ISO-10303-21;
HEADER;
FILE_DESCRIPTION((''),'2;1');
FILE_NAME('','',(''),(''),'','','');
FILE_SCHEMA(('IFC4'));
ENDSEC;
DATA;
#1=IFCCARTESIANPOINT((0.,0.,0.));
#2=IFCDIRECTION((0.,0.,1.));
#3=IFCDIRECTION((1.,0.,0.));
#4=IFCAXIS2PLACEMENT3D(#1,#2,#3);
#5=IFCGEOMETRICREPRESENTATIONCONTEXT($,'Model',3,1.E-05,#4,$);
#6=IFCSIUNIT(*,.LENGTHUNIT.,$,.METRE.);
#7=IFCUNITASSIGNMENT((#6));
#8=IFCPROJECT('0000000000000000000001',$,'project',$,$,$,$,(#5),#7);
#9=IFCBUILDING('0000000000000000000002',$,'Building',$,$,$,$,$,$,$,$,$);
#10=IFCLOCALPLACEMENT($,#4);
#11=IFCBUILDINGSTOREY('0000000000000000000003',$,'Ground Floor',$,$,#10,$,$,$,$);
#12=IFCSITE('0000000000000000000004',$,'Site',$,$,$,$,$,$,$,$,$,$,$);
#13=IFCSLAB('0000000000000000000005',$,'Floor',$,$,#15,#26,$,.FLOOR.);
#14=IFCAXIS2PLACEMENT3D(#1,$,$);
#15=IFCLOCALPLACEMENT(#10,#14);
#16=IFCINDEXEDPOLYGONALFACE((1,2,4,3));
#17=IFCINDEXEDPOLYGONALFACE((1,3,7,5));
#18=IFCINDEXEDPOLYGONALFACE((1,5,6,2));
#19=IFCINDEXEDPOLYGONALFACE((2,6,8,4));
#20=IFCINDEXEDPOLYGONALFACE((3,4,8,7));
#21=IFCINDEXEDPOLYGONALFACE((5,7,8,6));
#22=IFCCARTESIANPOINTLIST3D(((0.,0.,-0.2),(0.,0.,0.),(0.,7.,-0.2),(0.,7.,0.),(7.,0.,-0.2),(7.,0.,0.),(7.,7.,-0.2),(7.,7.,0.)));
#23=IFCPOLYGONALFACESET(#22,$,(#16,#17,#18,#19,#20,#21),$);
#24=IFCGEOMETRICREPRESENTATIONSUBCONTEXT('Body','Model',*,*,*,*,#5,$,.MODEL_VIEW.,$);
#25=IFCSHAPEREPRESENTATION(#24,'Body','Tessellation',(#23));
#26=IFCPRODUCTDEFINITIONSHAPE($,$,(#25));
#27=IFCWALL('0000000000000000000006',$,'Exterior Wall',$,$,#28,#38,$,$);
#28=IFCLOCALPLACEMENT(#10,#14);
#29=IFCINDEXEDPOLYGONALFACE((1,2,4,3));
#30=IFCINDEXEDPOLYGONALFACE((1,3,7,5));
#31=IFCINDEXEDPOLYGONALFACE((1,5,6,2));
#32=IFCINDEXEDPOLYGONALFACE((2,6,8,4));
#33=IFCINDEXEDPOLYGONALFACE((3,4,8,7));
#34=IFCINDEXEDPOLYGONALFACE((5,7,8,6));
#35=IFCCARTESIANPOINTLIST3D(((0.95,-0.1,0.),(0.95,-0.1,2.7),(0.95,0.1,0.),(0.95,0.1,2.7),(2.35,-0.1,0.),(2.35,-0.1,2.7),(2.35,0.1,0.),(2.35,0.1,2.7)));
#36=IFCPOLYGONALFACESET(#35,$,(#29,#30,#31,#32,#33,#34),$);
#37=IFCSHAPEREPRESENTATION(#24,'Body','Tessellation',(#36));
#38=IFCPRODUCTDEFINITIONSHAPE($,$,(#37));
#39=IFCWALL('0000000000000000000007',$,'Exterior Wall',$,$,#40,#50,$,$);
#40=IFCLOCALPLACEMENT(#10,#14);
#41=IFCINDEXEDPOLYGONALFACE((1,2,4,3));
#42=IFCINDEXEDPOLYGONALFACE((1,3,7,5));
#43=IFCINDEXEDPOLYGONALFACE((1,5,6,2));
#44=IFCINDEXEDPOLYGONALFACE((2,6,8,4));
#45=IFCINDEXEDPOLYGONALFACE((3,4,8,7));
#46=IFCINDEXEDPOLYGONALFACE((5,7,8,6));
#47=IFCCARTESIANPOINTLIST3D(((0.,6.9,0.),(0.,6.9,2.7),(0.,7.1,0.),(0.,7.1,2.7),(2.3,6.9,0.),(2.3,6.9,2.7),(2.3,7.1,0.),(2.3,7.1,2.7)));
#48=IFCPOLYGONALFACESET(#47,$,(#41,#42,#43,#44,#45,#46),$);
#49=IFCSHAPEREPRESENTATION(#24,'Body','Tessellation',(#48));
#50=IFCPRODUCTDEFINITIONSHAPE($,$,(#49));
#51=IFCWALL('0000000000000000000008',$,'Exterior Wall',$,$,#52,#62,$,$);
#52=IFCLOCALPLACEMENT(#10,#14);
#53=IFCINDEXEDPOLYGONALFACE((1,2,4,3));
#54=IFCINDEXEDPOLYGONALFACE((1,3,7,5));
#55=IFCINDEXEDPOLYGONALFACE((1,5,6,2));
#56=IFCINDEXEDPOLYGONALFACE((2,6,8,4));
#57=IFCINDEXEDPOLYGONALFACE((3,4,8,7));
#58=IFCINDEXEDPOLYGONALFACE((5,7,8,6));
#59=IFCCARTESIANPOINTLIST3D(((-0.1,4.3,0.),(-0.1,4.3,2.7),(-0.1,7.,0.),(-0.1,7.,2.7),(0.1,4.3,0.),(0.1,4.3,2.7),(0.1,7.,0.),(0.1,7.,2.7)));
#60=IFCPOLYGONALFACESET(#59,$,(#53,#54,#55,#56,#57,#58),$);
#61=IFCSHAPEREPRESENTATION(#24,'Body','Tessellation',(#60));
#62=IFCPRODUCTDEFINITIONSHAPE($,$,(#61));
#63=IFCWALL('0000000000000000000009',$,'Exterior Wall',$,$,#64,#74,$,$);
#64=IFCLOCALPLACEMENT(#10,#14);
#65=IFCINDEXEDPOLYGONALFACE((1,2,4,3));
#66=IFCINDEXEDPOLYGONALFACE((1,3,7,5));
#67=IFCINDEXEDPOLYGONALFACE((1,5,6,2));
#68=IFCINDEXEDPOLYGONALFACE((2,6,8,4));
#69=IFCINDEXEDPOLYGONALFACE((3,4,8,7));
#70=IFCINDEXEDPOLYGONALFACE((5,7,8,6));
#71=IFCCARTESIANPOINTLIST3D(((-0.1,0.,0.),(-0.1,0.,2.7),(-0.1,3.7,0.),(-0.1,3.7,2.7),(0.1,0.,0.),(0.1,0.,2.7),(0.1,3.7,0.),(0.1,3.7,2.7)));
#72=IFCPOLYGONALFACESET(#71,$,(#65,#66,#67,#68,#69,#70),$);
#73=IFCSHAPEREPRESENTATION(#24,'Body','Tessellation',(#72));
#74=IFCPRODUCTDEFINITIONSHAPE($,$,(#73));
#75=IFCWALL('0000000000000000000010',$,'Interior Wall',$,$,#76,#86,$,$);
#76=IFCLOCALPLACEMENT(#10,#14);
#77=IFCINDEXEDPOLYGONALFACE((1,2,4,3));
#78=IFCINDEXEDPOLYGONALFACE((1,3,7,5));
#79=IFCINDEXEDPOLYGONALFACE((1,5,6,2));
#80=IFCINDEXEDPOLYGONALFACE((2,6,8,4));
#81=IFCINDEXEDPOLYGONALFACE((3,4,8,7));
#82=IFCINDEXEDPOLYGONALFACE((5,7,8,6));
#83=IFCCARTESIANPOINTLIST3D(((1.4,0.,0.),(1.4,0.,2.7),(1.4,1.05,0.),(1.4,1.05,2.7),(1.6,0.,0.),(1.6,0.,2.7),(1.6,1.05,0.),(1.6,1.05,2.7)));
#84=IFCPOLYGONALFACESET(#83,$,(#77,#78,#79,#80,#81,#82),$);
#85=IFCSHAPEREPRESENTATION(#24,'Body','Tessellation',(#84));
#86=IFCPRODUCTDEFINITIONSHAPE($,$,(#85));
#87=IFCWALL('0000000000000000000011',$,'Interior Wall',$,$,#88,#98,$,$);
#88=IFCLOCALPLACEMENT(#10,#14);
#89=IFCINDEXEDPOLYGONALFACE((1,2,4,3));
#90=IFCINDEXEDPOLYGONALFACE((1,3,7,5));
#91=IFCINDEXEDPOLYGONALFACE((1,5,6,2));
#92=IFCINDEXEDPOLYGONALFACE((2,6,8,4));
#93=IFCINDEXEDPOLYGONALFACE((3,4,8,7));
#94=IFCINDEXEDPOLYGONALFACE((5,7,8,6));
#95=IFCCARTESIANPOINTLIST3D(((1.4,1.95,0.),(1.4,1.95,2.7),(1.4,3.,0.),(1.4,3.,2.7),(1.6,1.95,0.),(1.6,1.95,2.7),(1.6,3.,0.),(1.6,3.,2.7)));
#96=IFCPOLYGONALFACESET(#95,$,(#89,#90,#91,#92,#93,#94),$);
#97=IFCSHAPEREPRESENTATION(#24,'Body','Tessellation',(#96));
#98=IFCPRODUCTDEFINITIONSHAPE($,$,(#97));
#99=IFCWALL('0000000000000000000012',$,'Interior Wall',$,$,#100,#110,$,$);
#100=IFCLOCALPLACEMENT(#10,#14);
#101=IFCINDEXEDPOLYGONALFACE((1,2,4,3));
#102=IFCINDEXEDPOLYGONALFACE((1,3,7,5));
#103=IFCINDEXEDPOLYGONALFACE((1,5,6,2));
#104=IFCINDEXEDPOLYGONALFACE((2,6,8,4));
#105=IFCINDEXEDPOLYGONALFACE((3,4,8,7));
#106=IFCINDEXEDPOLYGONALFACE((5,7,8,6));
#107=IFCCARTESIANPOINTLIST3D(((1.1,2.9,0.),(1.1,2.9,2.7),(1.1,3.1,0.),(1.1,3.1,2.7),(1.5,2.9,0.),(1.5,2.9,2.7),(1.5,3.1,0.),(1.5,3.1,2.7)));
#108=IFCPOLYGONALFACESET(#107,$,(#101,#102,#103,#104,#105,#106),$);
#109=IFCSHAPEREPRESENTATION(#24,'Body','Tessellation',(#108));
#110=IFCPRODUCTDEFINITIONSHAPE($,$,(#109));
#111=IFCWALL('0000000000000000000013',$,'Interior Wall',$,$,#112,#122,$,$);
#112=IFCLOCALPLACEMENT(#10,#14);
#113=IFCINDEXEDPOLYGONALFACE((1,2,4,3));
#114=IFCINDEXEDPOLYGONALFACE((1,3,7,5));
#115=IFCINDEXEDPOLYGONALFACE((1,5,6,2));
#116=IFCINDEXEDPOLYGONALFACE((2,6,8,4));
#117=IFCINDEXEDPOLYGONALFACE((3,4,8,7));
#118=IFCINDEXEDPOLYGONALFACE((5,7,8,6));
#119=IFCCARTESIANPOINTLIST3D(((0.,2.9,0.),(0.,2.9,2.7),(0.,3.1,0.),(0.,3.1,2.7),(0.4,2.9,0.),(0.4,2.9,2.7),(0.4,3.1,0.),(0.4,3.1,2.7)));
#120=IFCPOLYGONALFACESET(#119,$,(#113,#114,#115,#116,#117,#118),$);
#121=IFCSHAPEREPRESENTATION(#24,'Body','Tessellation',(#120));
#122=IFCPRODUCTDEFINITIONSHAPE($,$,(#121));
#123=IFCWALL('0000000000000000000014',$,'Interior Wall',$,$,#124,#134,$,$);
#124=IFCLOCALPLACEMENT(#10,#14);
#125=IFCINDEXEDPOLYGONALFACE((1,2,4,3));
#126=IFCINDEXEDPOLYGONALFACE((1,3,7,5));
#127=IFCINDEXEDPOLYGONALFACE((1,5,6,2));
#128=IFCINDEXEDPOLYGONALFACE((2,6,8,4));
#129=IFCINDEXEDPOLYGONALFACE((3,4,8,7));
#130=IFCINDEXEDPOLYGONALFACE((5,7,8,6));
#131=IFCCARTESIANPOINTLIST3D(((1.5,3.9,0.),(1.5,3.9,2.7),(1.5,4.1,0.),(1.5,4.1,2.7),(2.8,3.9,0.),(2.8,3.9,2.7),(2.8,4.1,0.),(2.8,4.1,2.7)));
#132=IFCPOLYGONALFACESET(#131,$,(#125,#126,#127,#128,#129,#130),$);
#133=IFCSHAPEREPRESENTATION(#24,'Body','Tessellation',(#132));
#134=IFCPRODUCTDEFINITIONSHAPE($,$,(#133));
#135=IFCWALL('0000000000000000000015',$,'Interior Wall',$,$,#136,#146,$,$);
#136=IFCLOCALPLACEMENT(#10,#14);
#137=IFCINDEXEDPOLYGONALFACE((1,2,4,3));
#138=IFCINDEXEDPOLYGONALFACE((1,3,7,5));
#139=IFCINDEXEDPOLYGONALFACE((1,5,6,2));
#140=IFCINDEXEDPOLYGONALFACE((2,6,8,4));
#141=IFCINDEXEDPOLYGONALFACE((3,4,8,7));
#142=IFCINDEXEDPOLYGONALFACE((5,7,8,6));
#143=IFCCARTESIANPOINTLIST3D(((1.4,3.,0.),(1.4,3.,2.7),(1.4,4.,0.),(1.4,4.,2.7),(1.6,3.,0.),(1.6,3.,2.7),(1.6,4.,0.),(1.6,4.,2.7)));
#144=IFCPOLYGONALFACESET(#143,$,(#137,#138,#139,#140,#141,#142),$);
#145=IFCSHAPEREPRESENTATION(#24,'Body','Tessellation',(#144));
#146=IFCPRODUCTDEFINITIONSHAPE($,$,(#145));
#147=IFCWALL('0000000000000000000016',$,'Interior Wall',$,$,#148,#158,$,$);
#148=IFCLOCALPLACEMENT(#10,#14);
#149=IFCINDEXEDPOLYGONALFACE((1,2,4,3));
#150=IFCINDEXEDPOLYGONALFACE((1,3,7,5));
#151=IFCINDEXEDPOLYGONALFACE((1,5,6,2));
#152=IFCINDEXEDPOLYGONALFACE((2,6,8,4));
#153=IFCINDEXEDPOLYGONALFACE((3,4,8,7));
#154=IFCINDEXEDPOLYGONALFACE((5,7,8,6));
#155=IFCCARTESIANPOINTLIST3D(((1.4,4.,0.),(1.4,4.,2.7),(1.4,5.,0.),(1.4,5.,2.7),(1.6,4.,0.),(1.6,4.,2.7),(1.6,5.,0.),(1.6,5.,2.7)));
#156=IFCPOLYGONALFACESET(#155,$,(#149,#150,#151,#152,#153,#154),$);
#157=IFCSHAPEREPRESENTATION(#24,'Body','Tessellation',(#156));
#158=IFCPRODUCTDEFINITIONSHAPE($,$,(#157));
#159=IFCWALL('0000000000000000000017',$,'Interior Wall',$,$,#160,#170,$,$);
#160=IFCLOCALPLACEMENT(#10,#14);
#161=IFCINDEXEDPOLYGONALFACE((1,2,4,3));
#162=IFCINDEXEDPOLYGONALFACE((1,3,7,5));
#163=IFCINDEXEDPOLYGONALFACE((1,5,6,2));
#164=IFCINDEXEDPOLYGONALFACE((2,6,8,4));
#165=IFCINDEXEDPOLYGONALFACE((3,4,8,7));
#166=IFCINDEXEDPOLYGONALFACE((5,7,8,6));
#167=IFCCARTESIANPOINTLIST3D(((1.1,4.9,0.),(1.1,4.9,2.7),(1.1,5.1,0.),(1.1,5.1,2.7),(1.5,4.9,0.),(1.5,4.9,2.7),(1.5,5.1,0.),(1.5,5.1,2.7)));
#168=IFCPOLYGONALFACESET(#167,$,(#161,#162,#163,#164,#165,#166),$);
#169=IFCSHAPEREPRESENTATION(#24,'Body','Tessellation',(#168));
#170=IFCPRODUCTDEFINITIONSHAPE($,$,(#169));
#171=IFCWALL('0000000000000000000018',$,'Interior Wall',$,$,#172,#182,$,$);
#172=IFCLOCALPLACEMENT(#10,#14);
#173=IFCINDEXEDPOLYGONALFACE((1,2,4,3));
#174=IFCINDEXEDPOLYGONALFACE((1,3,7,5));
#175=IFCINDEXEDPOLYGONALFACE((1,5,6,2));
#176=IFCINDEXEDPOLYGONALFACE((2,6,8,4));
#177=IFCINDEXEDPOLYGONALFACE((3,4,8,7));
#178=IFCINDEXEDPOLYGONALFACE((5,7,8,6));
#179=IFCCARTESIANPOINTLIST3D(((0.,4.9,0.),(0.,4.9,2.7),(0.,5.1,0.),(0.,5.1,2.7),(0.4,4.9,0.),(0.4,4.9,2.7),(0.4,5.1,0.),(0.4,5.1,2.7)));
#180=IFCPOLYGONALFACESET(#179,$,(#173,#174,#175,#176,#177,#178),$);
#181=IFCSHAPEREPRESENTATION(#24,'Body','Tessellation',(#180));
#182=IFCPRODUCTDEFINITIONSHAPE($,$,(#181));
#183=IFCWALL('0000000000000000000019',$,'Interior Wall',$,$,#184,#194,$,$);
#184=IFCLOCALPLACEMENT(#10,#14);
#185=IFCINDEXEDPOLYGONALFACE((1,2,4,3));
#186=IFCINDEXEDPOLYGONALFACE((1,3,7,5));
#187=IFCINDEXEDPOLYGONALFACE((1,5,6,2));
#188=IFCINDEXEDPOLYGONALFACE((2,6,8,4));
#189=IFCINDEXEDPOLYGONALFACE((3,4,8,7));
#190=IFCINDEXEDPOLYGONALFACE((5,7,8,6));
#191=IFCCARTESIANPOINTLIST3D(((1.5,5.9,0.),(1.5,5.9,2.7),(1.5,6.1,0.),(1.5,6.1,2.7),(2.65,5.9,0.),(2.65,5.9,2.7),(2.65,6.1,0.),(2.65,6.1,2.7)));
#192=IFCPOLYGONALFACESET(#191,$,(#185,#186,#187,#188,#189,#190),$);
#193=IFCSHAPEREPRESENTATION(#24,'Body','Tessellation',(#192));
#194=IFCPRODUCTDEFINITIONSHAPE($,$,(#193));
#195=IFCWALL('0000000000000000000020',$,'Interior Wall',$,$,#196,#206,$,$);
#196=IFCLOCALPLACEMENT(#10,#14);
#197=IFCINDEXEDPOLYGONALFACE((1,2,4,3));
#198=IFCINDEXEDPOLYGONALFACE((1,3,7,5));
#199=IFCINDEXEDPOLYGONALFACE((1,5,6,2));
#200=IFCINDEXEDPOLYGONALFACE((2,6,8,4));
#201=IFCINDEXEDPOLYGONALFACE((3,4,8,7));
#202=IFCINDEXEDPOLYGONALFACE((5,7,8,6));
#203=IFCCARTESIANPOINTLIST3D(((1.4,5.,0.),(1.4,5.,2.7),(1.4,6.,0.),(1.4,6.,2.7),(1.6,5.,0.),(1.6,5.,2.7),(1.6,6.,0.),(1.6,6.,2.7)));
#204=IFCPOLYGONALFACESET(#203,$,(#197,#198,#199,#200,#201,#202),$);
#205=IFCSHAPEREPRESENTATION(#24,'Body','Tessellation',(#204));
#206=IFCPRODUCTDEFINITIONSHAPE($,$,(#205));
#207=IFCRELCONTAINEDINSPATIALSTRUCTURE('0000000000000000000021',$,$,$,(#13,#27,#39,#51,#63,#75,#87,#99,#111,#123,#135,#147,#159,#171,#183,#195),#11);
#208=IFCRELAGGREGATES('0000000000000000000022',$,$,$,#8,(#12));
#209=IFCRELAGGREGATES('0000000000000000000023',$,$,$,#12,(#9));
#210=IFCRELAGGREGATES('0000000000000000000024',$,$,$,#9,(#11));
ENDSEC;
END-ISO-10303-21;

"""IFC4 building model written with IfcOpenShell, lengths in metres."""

from ifc_helpers import new_model, si_unit, frame, origin_with_axes, place, context, subcontext, project, spatial, indexed_curve, outline, extrude, element, save


model = new_model("IFC4")

# Units and contexts
model_context = context("Model", 3, precision=1e-05, world=origin_with_axes())
body_context = subcontext(model_context, "Body", "Model", "MODEL_VIEW")
ifc_project = project(units=[si_unit("LENGTHUNIT", "METRE")], contexts=[model_context])

# Site, building, storey
site = spatial("IfcSite", under=ifc_project, Name="Site")
building = spatial("IfcBuilding", under=site, Name="Building")
storey_placement = place(None, origin_with_axes())
storey = spatial("IfcBuildingStorey", under=building, at=storey_placement, Name="Ground Floor")

# Slab
slab_placement = place(storey_placement, frame((0.0, 0.0, -0.2), z_axis=(0.0, 0.0, 1.0), x_axis=(1.0, 0.0, 0.0)))
element("IfcSlab", 1, at=slab_placement, inside=storey, Name="Floor", PredefinedType="FLOOR", context=body_context, shape_type="SweptSolid", body=[
    extrude(outline(indexed_curve([(0.0, 0.0), (7.0, 0.0), (7.0, 7.0), (0.0, 7.0)])), None, (0.0, 0.0, 1.0), 0.2),
])

# Walls
wall_1_placement = place(storey_placement, frame((0.95, 0.0, 0.0), z_axis=(0.0, 0.0, 1.0), x_axis=(1.0, 0.0, 0.0)))
element("IfcWall", 2, at=wall_1_placement, inside=storey, Name="Exterior Wall", context=body_context, shape_type="SweptSolid", body=[
    extrude(outline(indexed_curve([(0.0, 0.0), (0.0, 0.2), (1.4, 0.2), (1.4, 0.0), (0.0, 0.0)], self_intersect=False)), frame((0.0, -0.1, 0.0), z_axis=(0.0, 0.0, 1.0), x_axis=(1.0, 0.0, 0.0)), (0.0, 0.0, 1.0), 2.7),
])
wall_2_placement = place(storey_placement, frame((2.3, 7.0, 0.0), z_axis=(0.0, 0.0, 1.0), x_axis=(-1.0, 0.0, 0.0)))
element("IfcWall", 3, at=wall_2_placement, inside=storey, Name="Exterior Wall", context=body_context, shape_type="SweptSolid", body=[
    extrude(outline(indexed_curve([(0.0, 0.0), (0.0, 0.2), (2.3, 0.2), (2.3, 0.0), (0.0, 0.0)], self_intersect=False)), frame((0.0, -0.1, 0.0), z_axis=(0.0, 0.0, 1.0), x_axis=(1.0, 0.0, 0.0)), (0.0, 0.0, 1.0), 2.7),
])
wall_3_placement = place(storey_placement, frame((0.0, 7.0, 0.0), z_axis=(0.0, 0.0, 1.0), x_axis=(0.0, -1.0, 0.0)))
element("IfcWall", 4, at=wall_3_placement, inside=storey, Name="Exterior Wall", context=body_context, shape_type="SweptSolid", body=[
    extrude(outline(indexed_curve([(0.0, 0.0), (0.0, 0.2), (2.7, 0.2), (2.7, 0.0), (0.0, 0.0)], self_intersect=False)), frame((0.0, -0.1, 0.0), z_axis=(0.0, 0.0, 1.0), x_axis=(1.0, 0.0, 0.0)), (0.0, 0.0, 1.0), 2.7),
])
wall_4_placement = place(storey_placement, frame((0.0, 3.7, 0.0), z_axis=(0.0, 0.0, 1.0), x_axis=(0.0, -1.0, 0.0)))
element("IfcWall", 5, at=wall_4_placement, inside=storey, Name="Exterior Wall", context=body_context, shape_type="SweptSolid", body=[
    extrude(outline(indexed_curve([(0.0, 0.0), (0.0, 0.2), (3.7, 0.2), (3.7, 0.0), (0.0, 0.0)], self_intersect=False)), frame((0.0, -0.1, 0.0), z_axis=(0.0, 0.0, 1.0), x_axis=(1.0, 0.0, 0.0)), (0.0, 0.0, 1.0), 2.7),
])
for number, where, z_axis, x_axis, name in (
    (6, (1.5, 0.0, 0.0), (0.0, 0.0, 1.0), (0.0, 1.0, 0.0), "Interior Wall"),
    (7, (1.5, 1.95, 0.0), (0.0, 0.0, 1.0), (0.0, 1.0, 0.0), "Interior Wall"),
):
    element("IfcWall", number, at=place(storey_placement, frame(where, z_axis=z_axis, x_axis=x_axis)), inside=storey, Name=name, context=body_context, shape_type="SweptSolid", body=[
        extrude(outline(indexed_curve([(0.0, 0.0), (0.0, 0.2), (1.05, 0.2), (1.05, 0.0), (0.0, 0.0)], self_intersect=False)), frame((0.0, -0.1, 0.0), z_axis=(0.0, 0.0, 1.0), x_axis=(1.0, 0.0, 0.0)), (0.0, 0.0, 1.0), 2.7),
    ])
for number, where, z_axis, x_axis, name in (
    (8, (1.5, 3.0, 0.0), (0.0, 0.0, 1.0), (-1.0, 0.0, 0.0), "Interior Wall"),
    (9, (0.4, 3.0, 0.0), (0.0, 0.0, 1.0), (-1.0, 0.0, 0.0), "Interior Wall"),
):
    element("IfcWall", number, at=place(storey_placement, frame(where, z_axis=z_axis, x_axis=x_axis)), inside=storey, Name=name, context=body_context, shape_type="SweptSolid", body=[
        extrude(outline(indexed_curve([(0.0, 0.0), (0.0, 0.2), (0.4, 0.2), (0.4, 0.0), (0.0, 0.0)], self_intersect=False)), frame((0.0, -0.1, 0.0), z_axis=(0.0, 0.0, 1.0), x_axis=(1.0, 0.0, 0.0)), (0.0, 0.0, 1.0), 2.7),
    ])
wall_5_placement = place(storey_placement, frame((2.8, 4.0, 0.0), z_axis=(0.0, 0.0, 1.0), x_axis=(-1.0, 0.0, 0.0)))
element("IfcWall", 10, at=wall_5_placement, inside=storey, Name="Interior Wall", context=body_context, shape_type="SweptSolid", body=[
    extrude(outline(indexed_curve([(0.0, 0.0), (0.0, 0.2), (1.3, 0.2), (1.3, 0.0), (0.0, 0.0)], self_intersect=False)), frame((0.0, -0.1, 0.0), z_axis=(0.0, 0.0, 1.0), x_axis=(1.0, 0.0, 0.0)), (0.0, 0.0, 1.0), 2.7),
])
for number, where, z_axis, x_axis, name in (
    (11, (1.5, 4.0, 0.0), (0.0, 0.0, 1.0), (0.0, -1.0, 0.0), "Interior Wall"),
    (12, (1.5, 4.0, 0.0), (0.0, 0.0, 1.0), (0.0, 1.0, 0.0), "Interior Wall"),
):
    element("IfcWall", number, at=place(storey_placement, frame(where, z_axis=z_axis, x_axis=x_axis)), inside=storey, Name=name, context=body_context, shape_type="SweptSolid", body=[
        extrude(outline(indexed_curve([(0.0, 0.0), (0.0, 0.2), (1.0, 0.2), (1.0, 0.0), (0.0, 0.0)], self_intersect=False)), frame((0.0, -0.1, 0.0), z_axis=(0.0, 0.0, 1.0), x_axis=(1.0, 0.0, 0.0)), (0.0, 0.0, 1.0), 2.7),
    ])
for number, where, z_axis, x_axis, name in (
    (13, (1.5, 5.0, 0.0), (0.0, 0.0, 1.0), (-1.0, 0.0, 0.0), "Interior Wall"),
    (14, (0.4, 5.0, 0.0), (0.0, 0.0, 1.0), (-1.0, 0.0, 0.0), "Interior Wall"),
):
    element("IfcWall", number, at=place(storey_placement, frame(where, z_axis=z_axis, x_axis=x_axis)), inside=storey, Name=name, context=body_context, shape_type="SweptSolid", body=[
        extrude(outline(indexed_curve([(0.0, 0.0), (0.0, 0.2), (0.4, 0.2), (0.4, 0.0), (0.0, 0.0)], self_intersect=False)), frame((0.0, -0.1, 0.0), z_axis=(0.0, 0.0, 1.0), x_axis=(1.0, 0.0, 0.0)), (0.0, 0.0, 1.0), 2.7),
    ])
wall_6_placement = place(storey_placement, frame((2.65, 6.0, 0.0), z_axis=(0.0, 0.0, 1.0), x_axis=(-1.0, 0.0, 0.0)))
element("IfcWall", 15, at=wall_6_placement, inside=storey, Name="Interior Wall", context=body_context, shape_type="SweptSolid", body=[
    extrude(outline(indexed_curve([(0.0, 0.0), (0.0, 0.2), (1.15, 0.2), (1.15, 0.0), (0.0, 0.0)], self_intersect=False)), frame((0.0, -0.1, 0.0), z_axis=(0.0, 0.0, 1.0), x_axis=(1.0, 0.0, 0.0)), (0.0, 0.0, 1.0), 2.7),
])
wall_7_placement = place(storey_placement, frame((1.5, 6.0, 0.0), z_axis=(0.0, 0.0, 1.0), x_axis=(0.0, -1.0, 0.0)))
element("IfcWall", 16, at=wall_7_placement, inside=storey, Name="Interior Wall", context=body_context, shape_type="SweptSolid", body=[
    extrude(outline(indexed_curve([(0.0, 0.0), (0.0, 0.2), (1.0, 0.2), (1.0, 0.0), (0.0, 0.0)], self_intersect=False)), frame((0.0, -0.1, 0.0), z_axis=(0.0, 0.0, 1.0), x_axis=(1.0, 0.0, 0.0)), (0.0, 0.0, 1.0), 2.7),
])

save(model, "model.ifc")
